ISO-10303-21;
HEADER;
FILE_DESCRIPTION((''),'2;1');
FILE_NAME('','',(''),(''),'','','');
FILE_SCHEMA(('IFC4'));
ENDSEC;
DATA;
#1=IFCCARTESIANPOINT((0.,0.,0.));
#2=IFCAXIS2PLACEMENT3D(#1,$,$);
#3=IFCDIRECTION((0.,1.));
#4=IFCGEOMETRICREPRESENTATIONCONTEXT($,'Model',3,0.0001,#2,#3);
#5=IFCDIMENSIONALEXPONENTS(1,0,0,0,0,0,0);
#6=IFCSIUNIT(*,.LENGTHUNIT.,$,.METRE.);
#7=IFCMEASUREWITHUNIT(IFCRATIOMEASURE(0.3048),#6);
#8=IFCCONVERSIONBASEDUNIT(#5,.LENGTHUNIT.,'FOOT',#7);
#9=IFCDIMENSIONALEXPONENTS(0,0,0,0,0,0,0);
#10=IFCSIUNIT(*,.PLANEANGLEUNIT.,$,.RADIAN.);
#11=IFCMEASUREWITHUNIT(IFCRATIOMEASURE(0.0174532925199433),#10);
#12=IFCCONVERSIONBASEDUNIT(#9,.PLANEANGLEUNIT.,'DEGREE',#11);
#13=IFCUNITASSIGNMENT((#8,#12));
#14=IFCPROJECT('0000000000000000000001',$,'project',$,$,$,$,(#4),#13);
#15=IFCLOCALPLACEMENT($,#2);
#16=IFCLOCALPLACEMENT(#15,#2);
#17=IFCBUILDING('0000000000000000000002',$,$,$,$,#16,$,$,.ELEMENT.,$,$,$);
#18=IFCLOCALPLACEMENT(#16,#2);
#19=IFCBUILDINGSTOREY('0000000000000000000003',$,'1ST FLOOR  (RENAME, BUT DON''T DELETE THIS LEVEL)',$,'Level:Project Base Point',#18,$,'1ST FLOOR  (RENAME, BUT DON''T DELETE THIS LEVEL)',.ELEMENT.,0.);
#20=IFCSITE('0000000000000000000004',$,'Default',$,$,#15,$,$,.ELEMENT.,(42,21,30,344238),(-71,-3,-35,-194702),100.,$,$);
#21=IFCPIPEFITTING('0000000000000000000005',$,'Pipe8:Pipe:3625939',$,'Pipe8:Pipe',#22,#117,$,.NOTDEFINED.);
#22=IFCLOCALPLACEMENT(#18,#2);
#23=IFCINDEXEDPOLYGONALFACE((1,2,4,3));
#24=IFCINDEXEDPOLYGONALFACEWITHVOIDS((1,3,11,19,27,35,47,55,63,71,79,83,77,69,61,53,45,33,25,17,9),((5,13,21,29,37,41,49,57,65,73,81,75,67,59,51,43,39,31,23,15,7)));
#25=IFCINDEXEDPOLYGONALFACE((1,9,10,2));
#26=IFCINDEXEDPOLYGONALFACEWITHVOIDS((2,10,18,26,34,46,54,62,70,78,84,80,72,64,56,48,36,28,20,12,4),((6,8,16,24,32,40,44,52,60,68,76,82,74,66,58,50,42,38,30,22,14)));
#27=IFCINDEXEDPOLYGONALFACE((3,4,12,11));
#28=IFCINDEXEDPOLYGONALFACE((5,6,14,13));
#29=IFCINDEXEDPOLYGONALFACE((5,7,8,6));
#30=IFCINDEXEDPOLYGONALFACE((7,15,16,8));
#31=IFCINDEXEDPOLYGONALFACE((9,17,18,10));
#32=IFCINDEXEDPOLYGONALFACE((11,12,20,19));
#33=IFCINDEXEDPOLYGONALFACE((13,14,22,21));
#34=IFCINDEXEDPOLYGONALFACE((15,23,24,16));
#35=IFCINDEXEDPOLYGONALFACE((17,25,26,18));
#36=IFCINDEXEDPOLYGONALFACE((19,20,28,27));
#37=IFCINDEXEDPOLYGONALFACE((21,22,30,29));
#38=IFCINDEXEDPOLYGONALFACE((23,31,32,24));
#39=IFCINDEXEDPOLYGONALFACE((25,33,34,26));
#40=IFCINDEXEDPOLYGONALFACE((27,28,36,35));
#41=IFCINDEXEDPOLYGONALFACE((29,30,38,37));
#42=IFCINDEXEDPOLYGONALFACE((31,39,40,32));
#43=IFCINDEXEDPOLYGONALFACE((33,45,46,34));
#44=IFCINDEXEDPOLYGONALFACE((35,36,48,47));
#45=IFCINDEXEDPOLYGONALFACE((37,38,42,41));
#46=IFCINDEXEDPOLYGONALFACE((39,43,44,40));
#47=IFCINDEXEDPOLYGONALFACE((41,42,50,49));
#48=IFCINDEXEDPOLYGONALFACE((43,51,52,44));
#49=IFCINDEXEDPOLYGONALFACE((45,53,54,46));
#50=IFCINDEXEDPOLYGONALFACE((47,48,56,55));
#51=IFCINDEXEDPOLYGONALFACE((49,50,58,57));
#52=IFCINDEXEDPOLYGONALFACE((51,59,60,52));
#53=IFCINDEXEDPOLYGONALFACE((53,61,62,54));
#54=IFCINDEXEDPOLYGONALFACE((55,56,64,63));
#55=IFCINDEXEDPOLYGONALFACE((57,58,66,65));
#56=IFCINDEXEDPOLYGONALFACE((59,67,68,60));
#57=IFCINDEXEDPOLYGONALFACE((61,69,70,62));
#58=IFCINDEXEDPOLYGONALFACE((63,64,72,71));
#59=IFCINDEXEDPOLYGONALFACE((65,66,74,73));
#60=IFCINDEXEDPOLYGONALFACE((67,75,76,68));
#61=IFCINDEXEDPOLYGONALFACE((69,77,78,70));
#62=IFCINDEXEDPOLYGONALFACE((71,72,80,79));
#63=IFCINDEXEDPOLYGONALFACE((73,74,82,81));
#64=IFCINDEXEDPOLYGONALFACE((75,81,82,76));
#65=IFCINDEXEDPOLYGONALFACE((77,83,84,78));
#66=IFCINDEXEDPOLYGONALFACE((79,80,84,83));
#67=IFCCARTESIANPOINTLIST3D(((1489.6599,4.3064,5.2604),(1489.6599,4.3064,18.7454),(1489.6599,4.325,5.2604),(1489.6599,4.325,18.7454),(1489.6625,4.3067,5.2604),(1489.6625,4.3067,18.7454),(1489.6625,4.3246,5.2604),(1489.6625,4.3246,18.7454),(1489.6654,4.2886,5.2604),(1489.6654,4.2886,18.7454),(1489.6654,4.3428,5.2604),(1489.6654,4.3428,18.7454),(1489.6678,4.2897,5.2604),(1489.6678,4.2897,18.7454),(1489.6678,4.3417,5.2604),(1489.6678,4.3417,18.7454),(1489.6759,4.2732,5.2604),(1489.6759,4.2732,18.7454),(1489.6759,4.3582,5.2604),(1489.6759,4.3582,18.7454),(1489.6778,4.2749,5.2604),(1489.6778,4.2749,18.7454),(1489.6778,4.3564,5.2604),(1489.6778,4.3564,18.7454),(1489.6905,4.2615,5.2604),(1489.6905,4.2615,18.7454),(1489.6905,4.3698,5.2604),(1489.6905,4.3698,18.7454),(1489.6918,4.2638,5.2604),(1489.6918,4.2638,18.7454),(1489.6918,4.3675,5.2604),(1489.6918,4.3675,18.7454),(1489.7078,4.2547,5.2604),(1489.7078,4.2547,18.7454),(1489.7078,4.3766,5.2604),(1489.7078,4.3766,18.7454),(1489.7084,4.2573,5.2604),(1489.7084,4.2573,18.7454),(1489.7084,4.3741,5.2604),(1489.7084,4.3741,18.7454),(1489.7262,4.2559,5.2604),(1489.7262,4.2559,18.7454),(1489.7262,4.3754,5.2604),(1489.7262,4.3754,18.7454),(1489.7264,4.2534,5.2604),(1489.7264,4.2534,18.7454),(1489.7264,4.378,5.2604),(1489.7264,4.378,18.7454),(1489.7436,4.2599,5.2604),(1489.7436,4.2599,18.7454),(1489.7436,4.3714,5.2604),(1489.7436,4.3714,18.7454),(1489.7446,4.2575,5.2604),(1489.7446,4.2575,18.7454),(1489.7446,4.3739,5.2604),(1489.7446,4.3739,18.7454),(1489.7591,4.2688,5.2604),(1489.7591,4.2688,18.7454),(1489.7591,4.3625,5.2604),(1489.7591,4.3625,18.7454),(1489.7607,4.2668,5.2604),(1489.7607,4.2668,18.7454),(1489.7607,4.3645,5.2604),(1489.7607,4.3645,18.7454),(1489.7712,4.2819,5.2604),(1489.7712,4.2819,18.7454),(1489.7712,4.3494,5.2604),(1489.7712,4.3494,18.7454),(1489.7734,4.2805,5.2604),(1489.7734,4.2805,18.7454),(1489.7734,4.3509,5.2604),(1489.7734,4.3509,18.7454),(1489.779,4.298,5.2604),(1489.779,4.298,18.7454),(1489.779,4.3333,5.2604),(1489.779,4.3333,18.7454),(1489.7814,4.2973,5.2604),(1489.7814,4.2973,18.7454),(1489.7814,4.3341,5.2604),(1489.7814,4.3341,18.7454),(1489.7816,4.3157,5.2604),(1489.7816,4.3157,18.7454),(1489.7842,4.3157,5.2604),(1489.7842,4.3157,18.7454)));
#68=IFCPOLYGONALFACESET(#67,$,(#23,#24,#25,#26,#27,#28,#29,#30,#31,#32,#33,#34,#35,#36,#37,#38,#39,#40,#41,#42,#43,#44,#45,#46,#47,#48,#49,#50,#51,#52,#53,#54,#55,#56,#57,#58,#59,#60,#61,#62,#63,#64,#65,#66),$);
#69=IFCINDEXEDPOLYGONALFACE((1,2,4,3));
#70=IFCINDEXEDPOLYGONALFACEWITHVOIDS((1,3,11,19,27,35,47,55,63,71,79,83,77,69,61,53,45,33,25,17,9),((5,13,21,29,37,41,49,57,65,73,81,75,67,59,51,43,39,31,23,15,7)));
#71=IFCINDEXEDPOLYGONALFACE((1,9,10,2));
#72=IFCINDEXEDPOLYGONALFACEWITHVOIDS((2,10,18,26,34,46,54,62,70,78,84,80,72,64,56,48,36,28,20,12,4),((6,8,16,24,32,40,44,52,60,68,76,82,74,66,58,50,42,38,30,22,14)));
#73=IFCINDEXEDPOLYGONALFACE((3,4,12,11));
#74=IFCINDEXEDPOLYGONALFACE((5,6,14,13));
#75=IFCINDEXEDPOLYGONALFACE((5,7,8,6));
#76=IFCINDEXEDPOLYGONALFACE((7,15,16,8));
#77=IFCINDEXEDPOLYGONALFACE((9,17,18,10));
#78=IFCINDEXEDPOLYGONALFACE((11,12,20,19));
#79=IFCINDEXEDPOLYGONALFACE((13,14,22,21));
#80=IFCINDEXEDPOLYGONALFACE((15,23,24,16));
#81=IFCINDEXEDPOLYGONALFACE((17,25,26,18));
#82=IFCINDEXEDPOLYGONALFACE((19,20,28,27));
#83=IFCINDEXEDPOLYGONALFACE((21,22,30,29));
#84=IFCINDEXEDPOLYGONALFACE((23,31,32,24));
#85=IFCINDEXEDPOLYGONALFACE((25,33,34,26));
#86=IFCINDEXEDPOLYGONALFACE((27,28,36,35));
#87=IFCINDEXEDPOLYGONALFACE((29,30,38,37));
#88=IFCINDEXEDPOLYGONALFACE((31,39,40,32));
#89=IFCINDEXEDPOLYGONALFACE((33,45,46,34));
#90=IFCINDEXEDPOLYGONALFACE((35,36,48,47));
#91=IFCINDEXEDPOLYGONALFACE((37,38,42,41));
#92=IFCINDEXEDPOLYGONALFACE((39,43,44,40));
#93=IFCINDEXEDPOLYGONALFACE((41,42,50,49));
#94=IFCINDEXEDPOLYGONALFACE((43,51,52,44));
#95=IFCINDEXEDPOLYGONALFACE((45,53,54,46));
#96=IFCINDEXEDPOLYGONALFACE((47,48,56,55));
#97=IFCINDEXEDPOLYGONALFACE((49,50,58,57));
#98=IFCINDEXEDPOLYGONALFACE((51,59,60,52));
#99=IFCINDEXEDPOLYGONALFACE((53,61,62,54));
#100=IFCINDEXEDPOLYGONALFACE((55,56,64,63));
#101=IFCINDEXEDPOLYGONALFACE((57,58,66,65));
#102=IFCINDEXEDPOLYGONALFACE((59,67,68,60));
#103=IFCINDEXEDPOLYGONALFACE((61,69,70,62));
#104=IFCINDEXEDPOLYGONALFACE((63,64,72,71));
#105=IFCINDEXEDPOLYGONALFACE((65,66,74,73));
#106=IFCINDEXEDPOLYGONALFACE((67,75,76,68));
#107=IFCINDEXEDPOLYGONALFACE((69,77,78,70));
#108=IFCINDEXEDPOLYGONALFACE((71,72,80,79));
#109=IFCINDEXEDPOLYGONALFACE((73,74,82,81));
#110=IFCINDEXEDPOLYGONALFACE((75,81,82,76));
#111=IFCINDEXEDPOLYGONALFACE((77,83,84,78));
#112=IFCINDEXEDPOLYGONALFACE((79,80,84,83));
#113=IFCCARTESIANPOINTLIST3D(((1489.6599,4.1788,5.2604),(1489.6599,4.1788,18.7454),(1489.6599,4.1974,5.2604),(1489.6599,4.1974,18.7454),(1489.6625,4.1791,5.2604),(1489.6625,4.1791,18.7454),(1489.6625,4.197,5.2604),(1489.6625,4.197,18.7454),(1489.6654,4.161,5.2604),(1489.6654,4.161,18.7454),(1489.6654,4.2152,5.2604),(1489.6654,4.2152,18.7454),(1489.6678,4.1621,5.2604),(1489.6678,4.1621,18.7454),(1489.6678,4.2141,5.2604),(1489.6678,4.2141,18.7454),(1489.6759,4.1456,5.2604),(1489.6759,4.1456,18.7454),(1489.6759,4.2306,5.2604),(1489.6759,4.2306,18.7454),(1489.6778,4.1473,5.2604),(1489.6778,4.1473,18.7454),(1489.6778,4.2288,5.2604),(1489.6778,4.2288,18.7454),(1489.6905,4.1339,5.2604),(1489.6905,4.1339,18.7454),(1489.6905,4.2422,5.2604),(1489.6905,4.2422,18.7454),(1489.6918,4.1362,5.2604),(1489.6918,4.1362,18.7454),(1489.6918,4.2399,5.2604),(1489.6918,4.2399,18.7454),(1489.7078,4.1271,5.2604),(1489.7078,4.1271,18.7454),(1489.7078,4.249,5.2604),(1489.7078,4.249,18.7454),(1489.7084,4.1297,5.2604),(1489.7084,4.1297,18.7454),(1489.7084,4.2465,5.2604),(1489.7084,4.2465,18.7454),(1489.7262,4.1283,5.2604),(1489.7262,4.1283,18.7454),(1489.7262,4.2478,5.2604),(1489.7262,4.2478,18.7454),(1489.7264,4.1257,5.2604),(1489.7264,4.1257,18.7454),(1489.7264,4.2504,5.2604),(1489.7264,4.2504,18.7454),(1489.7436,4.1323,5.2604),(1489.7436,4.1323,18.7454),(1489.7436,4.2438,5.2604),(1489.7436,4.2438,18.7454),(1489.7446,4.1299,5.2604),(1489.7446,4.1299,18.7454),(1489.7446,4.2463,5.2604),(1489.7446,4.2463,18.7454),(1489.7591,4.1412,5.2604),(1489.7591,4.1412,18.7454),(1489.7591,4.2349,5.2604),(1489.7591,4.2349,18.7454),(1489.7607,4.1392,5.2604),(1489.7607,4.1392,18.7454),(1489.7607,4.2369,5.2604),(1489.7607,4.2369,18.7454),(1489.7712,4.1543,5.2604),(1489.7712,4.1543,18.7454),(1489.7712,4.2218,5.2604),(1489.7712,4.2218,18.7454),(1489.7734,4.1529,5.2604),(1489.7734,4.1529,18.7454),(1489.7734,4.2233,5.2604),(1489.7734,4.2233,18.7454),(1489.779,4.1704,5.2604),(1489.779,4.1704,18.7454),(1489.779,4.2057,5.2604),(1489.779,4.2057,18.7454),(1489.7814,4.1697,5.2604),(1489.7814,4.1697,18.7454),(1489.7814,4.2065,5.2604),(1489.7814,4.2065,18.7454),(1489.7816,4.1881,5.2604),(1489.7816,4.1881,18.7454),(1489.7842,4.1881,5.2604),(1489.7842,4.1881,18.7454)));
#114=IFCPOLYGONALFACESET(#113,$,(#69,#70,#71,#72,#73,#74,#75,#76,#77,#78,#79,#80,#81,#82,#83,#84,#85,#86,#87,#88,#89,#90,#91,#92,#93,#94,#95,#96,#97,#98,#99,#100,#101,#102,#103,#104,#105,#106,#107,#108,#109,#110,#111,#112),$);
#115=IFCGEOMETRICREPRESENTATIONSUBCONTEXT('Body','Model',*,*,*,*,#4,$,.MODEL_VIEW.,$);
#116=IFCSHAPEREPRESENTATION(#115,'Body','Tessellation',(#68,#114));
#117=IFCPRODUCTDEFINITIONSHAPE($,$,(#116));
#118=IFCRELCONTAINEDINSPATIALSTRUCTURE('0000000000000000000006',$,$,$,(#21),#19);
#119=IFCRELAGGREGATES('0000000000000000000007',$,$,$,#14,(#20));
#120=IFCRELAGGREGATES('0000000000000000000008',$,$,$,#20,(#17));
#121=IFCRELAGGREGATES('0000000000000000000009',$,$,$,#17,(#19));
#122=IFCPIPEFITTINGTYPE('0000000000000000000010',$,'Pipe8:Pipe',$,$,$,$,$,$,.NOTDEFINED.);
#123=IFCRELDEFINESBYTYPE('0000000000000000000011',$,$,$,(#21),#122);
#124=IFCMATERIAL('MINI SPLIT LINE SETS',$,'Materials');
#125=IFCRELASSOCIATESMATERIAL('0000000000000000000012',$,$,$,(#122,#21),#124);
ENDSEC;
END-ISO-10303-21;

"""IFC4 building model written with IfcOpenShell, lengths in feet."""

from ifc_helpers import new_model, entity, si_unit, converted_unit, direction, frame, origin, origin_2d_with_axis, place, context, subcontext, project, spatial, hollow_circle, extrude, source, transform, mapped, material, type_object, type_shapes, element, save


model = new_model("IFC4")

# Units and contexts
model_context = context("Model", 3, precision=0.0001, world=origin(), true_north=direction((0.0, 1.0)))
body_context = subcontext(model_context, "Body", "Model", "MODEL_VIEW")
ifc_project = project(units=[converted_unit("LENGTHUNIT", "FOOT", entity("IfcRatioMeasure", 0.3048), si_unit("LENGTHUNIT", "METRE"), dimensions=[1, 0, 0, 0, 0, 0, 0]), converted_unit("PLANEANGLEUNIT", "DEGREE", entity("IfcRatioMeasure", 0.0174532925199433), si_unit("PLANEANGLEUNIT", "RADIAN"), dimensions=[0, 0, 0, 0, 0, 0, 0])], contexts=[model_context])

# Site, building, storey
site_placement = place(None, origin())
site = spatial("IfcSite", under=ifc_project, at=site_placement, Name="Default", CompositionType="ELEMENT", RefLatitude=(42, 21, 30, 344238), RefLongitude=(-71, -3, -35, -194702), RefElevation=100.0)
building_placement = place(site_placement, origin())
building = spatial("IfcBuilding", under=site, at=building_placement, CompositionType="ELEMENT")
storey_placement = place(building_placement, origin())
storey = spatial("IfcBuildingStorey", under=building, at=storey_placement, Name="1ST FLOOR  (RENAME, BUT DON'T DELETE THIS LEVEL)", ObjectType="Level:Project Base Point", LongName="1ST FLOOR  (RENAME, BUT DON'T DELETE THIS LEVEL)", CompositionType="ELEMENT", Elevation=0.0)

# Shared definitions
ifc_material_1 = material(Name="MINI SPLIT LINE SETS", Category="Materials")

# Pipe fitting
pipe_fitting_type_1 = type_object("IfcPipeFittingType", Name="Pipe8:Pipe", PredefinedType="NOTDEFINED", material=ifc_material_1)
shared_shape_1 = source(origin(), body_context, "Body", "SweptSolid", [
    extrude(hollow_circle(Radius=0.0625, WallThickness=0.0026, at=origin_2d_with_axis()), frame((0.0677, 0.1953, 0.0)), (0.0, 0.0, 1.0), 13.485),
    extrude(hollow_circle(Radius=0.0625, WallThickness=0.0026, at=origin_2d_with_axis()), frame((0.0677, 0.0677, 0.0)), (0.0, 0.0, 1.0), 13.485),
])
type_shapes(pipe_fitting_type_1, [shared_shape_1])
pipe_fitting_1_placement = place(storey_placement, frame((1489.654, 4.1203, 5.2604)))
element("IfcPipeFitting", 1, at=pipe_fitting_1_placement, inside=storey, type_object=pipe_fitting_type_1, material=ifc_material_1, Name="Pipe8:Pipe:3625939", ObjectType="Pipe8:Pipe", PredefinedType="NOTDEFINED", context=body_context, shape_type="MappedRepresentation", body=[
    mapped(shared_shape_1, transform((0.0, 0.0, 0.0), scale=1.0)),
])

save(model, "model.ifc")
